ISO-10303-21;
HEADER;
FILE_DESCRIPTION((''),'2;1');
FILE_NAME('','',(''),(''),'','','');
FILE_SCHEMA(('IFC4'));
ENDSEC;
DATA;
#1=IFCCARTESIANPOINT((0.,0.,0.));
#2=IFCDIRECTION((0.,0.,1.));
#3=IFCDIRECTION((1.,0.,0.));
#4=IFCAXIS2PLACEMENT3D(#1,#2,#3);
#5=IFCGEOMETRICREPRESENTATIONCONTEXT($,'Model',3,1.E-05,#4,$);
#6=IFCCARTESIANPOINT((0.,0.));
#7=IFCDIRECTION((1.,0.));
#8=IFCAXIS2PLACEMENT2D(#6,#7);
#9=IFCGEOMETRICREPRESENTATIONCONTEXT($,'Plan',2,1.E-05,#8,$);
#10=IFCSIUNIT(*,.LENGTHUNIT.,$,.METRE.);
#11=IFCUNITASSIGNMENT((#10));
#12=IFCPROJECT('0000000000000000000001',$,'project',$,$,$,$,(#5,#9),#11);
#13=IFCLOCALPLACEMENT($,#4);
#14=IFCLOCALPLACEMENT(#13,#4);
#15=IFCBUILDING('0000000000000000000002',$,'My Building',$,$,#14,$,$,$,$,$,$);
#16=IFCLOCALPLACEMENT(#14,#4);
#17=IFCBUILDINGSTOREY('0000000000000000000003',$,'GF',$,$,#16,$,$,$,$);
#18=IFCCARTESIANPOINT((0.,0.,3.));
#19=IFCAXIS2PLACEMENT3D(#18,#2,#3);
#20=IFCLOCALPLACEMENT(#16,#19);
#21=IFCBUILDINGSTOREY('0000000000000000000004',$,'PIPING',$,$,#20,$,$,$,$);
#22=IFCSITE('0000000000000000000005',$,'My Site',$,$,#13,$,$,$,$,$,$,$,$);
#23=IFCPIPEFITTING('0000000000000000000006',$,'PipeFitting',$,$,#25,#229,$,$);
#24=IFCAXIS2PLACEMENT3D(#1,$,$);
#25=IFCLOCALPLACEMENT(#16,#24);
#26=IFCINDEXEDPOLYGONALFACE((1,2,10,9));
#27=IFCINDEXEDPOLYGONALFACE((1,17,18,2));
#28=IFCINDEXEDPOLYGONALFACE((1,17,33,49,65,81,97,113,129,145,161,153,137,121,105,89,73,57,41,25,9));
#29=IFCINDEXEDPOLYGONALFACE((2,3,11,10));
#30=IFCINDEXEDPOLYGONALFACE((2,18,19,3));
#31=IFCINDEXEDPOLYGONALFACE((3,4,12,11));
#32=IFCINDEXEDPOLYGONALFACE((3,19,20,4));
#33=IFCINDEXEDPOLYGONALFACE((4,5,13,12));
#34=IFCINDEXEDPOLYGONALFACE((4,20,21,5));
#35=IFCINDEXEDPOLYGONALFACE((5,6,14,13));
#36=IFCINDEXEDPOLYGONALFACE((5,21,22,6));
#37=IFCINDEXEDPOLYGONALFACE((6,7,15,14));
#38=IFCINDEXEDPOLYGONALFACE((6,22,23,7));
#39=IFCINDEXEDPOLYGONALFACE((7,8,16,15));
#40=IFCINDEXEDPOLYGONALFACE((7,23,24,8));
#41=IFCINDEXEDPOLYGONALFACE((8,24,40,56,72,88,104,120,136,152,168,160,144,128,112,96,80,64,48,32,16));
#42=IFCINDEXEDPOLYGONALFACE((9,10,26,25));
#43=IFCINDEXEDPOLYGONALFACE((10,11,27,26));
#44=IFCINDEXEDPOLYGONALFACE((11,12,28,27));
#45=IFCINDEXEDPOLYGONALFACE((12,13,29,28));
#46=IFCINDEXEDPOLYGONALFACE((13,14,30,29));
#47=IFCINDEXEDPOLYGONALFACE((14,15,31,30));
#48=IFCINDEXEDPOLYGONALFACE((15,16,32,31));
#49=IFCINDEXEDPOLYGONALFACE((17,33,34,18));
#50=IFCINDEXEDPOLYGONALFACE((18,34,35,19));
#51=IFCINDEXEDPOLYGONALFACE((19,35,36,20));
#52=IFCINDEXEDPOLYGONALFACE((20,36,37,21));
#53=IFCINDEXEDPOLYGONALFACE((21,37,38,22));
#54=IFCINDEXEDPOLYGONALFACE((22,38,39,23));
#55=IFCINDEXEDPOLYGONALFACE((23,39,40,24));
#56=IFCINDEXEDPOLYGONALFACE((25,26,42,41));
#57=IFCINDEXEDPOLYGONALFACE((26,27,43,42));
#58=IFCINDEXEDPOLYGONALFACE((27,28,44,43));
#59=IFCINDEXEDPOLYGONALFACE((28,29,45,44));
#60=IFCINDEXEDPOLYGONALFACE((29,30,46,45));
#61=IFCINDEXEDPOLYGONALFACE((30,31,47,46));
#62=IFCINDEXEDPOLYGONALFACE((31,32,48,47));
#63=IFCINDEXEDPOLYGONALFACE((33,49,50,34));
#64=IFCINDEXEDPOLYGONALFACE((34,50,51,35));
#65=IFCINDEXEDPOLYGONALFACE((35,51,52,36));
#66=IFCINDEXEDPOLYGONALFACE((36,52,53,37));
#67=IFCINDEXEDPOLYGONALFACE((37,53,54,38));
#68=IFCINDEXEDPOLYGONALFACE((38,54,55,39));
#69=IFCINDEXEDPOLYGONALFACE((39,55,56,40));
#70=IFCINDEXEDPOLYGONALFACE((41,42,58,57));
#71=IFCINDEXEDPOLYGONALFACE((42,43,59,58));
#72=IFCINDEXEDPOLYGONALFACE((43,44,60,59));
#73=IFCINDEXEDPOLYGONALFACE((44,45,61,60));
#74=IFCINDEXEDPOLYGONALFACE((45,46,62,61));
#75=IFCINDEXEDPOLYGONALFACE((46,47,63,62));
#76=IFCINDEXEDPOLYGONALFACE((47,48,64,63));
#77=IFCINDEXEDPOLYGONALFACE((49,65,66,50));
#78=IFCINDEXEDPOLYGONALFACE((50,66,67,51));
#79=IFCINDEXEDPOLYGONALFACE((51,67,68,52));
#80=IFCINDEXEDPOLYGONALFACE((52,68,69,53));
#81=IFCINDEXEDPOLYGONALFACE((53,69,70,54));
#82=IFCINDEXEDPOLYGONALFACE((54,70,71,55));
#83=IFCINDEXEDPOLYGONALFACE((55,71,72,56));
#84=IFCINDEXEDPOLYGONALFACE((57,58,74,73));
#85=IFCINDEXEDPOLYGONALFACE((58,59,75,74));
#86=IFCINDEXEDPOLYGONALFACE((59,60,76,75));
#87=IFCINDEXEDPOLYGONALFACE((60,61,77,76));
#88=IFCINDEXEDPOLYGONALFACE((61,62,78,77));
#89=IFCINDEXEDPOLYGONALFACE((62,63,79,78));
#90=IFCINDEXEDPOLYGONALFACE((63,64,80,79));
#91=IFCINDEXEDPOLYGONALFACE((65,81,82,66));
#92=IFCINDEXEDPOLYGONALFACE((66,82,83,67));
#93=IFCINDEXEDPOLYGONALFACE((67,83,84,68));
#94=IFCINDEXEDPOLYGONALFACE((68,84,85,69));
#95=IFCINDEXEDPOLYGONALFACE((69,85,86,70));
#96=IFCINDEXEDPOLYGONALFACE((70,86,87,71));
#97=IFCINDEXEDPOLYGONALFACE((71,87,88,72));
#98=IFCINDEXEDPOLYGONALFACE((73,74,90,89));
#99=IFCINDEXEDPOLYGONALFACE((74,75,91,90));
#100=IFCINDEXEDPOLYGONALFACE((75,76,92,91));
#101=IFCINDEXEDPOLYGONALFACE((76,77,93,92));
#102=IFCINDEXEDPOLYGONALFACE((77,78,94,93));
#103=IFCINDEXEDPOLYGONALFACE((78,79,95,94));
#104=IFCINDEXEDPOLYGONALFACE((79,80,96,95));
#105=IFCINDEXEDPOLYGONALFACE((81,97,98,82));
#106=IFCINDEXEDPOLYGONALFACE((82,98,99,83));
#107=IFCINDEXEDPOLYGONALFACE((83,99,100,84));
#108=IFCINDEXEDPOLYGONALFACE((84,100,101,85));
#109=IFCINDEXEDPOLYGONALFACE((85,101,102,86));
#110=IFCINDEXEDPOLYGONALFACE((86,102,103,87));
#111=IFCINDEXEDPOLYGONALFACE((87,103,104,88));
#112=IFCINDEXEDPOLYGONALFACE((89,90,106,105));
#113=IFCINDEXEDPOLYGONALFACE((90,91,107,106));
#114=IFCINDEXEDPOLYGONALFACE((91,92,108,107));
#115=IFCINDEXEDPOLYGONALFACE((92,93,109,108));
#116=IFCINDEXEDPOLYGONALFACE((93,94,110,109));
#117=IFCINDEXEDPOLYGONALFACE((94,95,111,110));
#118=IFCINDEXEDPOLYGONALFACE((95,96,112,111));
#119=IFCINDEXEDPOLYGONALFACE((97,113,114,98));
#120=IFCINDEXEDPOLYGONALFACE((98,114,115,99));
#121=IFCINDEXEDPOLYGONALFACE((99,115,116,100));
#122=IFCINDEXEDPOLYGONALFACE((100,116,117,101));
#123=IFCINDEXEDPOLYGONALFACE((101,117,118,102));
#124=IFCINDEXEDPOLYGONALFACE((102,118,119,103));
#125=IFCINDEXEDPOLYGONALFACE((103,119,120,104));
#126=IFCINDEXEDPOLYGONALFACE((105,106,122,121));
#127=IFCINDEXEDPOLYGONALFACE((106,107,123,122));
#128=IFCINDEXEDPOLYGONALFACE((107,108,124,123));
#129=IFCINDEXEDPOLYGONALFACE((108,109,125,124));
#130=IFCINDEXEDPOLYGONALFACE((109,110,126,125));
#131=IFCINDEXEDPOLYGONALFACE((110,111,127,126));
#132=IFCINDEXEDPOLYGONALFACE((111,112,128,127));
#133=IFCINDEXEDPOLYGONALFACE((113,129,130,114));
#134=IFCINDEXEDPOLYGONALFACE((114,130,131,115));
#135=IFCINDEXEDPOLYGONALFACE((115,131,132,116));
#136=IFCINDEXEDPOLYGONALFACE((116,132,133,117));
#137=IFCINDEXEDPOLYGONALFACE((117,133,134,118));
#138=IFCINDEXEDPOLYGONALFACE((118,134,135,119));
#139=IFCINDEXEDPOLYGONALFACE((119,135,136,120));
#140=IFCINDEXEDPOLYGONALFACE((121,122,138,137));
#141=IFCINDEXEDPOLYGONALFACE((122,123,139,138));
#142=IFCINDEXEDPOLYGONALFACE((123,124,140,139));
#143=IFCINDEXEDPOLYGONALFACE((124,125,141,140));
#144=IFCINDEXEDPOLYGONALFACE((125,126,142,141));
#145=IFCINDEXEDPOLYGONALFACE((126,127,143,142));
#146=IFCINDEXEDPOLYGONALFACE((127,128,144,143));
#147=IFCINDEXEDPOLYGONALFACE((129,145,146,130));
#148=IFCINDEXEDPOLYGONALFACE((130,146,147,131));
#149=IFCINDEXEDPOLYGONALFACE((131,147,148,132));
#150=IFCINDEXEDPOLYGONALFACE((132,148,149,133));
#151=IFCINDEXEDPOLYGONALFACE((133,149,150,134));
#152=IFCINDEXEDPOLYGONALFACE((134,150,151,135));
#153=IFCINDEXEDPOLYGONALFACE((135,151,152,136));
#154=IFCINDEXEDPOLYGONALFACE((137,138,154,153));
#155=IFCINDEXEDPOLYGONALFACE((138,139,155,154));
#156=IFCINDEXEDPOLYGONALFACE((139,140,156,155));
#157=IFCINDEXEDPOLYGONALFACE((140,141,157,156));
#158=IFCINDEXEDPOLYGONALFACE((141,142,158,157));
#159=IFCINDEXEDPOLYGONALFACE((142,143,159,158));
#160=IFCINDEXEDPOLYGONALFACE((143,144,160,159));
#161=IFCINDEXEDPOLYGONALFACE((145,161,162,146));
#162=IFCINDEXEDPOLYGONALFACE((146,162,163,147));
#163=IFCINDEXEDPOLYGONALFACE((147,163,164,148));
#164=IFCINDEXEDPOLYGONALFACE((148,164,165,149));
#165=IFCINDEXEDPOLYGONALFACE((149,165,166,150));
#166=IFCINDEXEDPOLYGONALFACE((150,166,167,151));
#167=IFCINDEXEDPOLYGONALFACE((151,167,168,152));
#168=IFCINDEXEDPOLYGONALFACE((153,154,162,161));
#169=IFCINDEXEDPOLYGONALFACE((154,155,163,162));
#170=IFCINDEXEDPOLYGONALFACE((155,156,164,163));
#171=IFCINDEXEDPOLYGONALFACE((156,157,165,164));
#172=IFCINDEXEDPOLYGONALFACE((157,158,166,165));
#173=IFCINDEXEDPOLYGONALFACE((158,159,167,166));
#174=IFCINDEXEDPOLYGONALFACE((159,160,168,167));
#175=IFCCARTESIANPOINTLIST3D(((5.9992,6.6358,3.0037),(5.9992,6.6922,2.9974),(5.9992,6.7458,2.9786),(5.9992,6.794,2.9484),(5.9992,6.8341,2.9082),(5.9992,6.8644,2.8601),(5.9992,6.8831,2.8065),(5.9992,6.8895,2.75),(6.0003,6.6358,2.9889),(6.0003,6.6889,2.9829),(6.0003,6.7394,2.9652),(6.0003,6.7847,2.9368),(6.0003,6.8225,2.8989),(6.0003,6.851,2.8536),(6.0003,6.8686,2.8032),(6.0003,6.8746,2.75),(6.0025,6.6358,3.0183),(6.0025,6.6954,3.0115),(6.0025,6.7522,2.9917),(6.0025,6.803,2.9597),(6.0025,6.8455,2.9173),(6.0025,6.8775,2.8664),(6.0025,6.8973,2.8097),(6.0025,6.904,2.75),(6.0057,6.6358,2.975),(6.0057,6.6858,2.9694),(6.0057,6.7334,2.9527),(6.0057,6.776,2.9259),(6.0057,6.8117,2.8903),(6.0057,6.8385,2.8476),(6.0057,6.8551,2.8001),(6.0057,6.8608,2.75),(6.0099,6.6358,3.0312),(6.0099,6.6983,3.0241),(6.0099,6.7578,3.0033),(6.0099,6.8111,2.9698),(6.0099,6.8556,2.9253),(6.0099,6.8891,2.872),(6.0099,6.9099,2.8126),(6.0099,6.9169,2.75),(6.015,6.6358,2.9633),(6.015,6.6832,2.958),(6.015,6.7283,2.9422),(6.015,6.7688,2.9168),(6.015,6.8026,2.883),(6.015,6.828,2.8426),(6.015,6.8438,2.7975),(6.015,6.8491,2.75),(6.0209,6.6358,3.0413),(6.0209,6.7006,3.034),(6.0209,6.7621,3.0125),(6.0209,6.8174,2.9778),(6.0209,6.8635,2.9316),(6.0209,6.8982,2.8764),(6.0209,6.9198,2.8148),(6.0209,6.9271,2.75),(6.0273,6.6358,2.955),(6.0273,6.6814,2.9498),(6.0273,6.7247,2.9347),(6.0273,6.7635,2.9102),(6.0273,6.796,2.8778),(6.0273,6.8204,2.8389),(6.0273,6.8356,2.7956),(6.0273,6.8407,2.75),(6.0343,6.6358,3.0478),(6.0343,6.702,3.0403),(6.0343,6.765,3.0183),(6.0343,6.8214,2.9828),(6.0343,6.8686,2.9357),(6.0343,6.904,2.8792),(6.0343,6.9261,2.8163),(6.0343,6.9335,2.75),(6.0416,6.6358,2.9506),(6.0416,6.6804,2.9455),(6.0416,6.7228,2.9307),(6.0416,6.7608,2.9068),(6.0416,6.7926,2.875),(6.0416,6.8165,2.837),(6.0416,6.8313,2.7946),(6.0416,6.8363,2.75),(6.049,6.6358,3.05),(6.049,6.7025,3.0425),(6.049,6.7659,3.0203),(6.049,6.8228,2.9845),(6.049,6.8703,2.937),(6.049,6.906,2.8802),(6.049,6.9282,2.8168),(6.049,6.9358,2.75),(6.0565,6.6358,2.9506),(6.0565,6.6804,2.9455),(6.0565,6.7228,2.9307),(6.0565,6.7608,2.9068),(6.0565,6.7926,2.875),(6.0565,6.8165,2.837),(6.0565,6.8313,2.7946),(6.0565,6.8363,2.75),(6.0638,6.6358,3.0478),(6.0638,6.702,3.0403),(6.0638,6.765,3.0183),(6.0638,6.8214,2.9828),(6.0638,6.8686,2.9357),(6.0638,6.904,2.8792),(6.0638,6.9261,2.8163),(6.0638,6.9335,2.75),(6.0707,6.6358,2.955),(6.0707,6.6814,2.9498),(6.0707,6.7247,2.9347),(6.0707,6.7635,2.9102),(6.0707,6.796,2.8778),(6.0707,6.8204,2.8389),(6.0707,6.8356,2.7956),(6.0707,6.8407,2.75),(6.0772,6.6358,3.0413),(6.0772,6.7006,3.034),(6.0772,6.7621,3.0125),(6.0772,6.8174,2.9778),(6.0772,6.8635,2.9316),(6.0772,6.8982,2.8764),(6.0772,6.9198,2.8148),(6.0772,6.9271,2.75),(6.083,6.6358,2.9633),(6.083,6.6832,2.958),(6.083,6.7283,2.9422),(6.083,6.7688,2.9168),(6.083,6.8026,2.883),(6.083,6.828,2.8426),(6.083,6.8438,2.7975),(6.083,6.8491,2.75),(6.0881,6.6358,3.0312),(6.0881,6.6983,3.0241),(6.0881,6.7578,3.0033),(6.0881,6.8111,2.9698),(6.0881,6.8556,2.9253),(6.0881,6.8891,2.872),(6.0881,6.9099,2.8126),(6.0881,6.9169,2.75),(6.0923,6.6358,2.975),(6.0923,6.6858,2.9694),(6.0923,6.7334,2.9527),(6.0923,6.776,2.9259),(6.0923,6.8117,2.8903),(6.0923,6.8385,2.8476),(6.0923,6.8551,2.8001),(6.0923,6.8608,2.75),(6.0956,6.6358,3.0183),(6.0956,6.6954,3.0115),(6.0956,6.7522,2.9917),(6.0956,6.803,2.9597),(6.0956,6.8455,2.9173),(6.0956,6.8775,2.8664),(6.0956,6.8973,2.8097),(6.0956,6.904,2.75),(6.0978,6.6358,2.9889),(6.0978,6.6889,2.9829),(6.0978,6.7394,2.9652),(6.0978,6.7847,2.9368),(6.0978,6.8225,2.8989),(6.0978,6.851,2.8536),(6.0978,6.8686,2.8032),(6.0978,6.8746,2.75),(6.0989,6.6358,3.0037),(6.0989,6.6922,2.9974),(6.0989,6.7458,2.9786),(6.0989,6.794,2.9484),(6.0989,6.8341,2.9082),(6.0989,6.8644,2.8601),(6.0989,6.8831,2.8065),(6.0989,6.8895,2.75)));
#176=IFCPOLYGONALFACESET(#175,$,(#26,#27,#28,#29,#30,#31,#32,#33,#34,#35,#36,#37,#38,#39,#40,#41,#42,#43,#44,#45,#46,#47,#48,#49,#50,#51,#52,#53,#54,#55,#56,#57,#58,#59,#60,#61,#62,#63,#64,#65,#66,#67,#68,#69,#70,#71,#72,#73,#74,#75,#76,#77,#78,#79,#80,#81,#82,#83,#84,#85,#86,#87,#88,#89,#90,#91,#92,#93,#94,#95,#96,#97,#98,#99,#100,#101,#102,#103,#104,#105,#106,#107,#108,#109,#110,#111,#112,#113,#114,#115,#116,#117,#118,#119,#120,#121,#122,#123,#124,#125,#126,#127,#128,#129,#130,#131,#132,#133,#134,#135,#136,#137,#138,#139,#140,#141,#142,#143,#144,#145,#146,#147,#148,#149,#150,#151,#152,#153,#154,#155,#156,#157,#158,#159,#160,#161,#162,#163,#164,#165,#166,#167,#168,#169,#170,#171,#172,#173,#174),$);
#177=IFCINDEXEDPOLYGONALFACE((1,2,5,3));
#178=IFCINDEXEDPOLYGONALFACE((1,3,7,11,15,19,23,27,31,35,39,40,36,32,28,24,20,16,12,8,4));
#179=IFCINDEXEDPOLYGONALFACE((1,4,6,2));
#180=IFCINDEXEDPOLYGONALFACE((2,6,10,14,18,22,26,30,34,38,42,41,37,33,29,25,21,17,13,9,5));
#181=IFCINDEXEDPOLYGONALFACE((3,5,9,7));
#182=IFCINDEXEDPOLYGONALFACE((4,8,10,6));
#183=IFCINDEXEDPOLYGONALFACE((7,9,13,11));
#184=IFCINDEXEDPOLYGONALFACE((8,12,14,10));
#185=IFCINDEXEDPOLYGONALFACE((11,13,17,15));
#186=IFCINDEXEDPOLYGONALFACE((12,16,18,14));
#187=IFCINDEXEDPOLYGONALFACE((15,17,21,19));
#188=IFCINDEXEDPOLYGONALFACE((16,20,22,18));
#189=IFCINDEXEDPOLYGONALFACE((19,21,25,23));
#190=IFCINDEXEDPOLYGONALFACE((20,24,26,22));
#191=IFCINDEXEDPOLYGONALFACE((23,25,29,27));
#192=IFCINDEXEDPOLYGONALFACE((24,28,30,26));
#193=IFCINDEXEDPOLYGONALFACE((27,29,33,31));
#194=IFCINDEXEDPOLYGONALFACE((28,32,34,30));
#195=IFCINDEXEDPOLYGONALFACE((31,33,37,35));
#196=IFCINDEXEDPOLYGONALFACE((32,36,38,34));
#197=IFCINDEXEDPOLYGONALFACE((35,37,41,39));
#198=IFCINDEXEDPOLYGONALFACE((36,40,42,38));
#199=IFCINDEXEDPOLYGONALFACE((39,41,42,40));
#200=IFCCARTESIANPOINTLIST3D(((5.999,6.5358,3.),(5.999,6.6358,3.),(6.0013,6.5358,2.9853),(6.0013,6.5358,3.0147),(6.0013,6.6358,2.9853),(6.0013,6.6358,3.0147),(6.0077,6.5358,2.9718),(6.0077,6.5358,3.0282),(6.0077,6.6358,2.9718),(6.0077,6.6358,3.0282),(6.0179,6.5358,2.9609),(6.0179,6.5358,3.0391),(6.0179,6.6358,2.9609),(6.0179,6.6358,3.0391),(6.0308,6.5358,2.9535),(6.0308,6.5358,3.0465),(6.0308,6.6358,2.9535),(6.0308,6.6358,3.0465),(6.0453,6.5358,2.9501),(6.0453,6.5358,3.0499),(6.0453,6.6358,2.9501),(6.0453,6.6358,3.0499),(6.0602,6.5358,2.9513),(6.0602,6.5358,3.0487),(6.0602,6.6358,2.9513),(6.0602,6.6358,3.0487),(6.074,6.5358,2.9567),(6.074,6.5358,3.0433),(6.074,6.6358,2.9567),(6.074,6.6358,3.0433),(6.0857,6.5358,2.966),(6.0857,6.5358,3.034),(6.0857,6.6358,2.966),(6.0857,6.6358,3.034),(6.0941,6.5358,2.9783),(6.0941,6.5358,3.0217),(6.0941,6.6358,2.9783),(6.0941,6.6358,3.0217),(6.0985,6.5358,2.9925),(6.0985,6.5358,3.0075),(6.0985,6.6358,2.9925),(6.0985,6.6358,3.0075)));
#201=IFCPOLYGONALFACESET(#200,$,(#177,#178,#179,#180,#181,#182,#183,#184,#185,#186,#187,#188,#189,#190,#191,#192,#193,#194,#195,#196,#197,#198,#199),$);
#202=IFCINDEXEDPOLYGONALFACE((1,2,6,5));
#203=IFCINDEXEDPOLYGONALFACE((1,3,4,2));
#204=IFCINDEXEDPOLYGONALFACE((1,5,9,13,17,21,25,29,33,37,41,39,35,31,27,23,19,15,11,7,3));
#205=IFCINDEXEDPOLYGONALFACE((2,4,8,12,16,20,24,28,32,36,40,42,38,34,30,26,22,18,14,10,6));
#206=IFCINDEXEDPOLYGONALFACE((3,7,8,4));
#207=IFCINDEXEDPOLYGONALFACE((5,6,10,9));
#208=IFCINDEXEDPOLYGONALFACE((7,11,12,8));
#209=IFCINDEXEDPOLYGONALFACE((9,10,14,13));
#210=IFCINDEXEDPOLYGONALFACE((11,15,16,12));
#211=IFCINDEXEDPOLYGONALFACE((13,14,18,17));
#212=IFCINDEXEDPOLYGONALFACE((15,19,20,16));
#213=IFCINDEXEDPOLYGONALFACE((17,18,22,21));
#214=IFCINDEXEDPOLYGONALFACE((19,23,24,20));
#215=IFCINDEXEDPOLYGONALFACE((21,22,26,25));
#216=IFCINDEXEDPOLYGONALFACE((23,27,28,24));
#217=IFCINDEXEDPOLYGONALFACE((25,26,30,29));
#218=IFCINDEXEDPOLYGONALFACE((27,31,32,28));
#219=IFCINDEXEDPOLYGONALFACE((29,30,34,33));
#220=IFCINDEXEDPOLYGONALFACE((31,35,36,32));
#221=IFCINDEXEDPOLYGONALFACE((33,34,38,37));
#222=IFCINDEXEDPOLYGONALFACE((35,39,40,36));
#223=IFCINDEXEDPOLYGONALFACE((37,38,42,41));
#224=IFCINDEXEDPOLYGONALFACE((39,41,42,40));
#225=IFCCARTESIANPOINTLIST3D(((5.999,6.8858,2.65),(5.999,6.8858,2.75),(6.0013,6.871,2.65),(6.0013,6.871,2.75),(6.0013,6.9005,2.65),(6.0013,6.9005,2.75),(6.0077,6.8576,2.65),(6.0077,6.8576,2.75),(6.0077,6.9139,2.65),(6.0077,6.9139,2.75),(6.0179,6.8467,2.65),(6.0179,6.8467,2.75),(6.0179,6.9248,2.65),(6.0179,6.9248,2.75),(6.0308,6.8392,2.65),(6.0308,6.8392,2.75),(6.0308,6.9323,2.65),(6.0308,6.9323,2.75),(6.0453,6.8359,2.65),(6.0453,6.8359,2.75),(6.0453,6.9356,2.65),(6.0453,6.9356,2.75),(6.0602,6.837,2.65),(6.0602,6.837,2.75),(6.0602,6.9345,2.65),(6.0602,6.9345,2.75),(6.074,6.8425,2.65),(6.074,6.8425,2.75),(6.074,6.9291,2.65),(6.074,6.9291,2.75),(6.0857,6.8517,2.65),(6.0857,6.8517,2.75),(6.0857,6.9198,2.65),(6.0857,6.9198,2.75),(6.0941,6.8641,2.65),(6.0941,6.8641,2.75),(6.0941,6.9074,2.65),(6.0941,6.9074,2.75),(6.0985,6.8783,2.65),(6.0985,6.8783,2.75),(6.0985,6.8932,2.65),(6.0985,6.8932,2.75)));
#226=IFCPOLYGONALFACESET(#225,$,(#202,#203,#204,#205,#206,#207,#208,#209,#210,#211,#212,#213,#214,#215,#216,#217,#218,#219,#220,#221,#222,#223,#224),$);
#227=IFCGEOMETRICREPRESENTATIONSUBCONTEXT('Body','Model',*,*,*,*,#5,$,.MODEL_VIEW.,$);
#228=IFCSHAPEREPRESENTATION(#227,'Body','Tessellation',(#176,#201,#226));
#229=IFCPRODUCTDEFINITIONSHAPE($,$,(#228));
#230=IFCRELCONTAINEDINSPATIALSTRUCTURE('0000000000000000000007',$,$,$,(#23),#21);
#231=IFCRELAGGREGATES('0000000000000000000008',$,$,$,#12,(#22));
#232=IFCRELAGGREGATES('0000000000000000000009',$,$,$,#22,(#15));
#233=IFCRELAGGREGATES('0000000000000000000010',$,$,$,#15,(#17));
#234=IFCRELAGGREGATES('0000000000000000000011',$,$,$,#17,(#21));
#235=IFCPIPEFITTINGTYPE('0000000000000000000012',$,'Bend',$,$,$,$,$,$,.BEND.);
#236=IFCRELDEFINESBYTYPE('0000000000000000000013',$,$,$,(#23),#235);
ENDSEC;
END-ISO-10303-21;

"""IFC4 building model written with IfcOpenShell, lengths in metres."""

from ifc_helpers import new_model, entity, si_unit, frame, origin_with_axes, origin_2d_with_axis, place, context, subcontext, project, spatial, circle, extrude, source, transform, mapped, type_object, type_shapes, element, save


model = new_model("IFC4")

# Units and contexts
model_context = context("Model", 3, precision=1e-05, world=origin_with_axes())
plan_context = context("Plan", 2, precision=1e-05, world=origin_2d_with_axis())
body_context = subcontext(model_context, "Body", "Model", "MODEL_VIEW")
ifc_project = project(units=[si_unit("LENGTHUNIT", "METRE")], contexts=[model_context, plan_context])

# Site, building, storeys
site_placement = place(None, origin_with_axes())
site = spatial("IfcSite", under=ifc_project, at=site_placement, Name="My Site")
building_placement = place(site_placement, origin_with_axes())
building = spatial("IfcBuilding", under=site, at=building_placement, Name="My Building")
storey_1_placement = place(building_placement, origin_with_axes())
storey_1 = spatial("IfcBuildingStorey", under=building, at=storey_1_placement, Name="GF")
storey_2_placement = place(storey_1_placement, frame((0.0, 0.0, 3.0), z_axis=(0.0, 0.0, 1.0), x_axis=(1.0, 0.0, 0.0)))
storey_2 = spatial("IfcBuildingStorey", under=storey_1, at=storey_2_placement, Name="PIPING")

# Pipe fitting
pipe_fitting_type = type_object("IfcPipeFittingType", Name="Bend", PredefinedType="BEND")
shared_shape = source(origin_with_axes(), body_context, "Body", "SolidModel", [
    entity("IfcSweptDiskSolid", entity("IfcIndexedPolyCurve", entity("IfcCartesianPointList3D", [[0.0, 0.0, -0.1], [0.0, 0.0732, -0.2768], [0.0, 0.25, -0.35]]), [entity("IfcArcIndex", [1, 2, 3])]), 0.05),
    extrude(circle(Radius=0.05), origin_with_axes(), (0.0, 0.0, -1.0), 0.1),
    extrude(circle(Radius=0.05), frame((0.0, 0.25, -0.35), z_axis=(0.0, 1.0, 0.0), x_axis=(1.0, 0.0, 0.0)), (0.0, 0.0, 1.0), 0.1),
])
type_shapes(pipe_fitting_type, [shared_shape])
for number, where, z_axis, x_axis, name in (
    (1, (6.049, 6.5358, 0.0), (0.0, -1.0, 0.0), (-1.0, 0.0, 0.0), "PipeFitting"),
):
    element("IfcPipeFitting", number, at=place(storey_2_placement, frame(where, z_axis=z_axis, x_axis=x_axis)), inside=storey_2, type_object=pipe_fitting_type, Name=name, context=body_context, shape_type="MappedRepresentation", body=[
        mapped(shared_shape, transform((0.0, 0.0, 0.0), x_axis=(1.0, 0.0, 0.0), y_axis=(0.0, 1.0, 0.0), z_axis=(0.0, 0.0, 1.0), scale=1.0)),
    ])

save(model, "model.ifc")
